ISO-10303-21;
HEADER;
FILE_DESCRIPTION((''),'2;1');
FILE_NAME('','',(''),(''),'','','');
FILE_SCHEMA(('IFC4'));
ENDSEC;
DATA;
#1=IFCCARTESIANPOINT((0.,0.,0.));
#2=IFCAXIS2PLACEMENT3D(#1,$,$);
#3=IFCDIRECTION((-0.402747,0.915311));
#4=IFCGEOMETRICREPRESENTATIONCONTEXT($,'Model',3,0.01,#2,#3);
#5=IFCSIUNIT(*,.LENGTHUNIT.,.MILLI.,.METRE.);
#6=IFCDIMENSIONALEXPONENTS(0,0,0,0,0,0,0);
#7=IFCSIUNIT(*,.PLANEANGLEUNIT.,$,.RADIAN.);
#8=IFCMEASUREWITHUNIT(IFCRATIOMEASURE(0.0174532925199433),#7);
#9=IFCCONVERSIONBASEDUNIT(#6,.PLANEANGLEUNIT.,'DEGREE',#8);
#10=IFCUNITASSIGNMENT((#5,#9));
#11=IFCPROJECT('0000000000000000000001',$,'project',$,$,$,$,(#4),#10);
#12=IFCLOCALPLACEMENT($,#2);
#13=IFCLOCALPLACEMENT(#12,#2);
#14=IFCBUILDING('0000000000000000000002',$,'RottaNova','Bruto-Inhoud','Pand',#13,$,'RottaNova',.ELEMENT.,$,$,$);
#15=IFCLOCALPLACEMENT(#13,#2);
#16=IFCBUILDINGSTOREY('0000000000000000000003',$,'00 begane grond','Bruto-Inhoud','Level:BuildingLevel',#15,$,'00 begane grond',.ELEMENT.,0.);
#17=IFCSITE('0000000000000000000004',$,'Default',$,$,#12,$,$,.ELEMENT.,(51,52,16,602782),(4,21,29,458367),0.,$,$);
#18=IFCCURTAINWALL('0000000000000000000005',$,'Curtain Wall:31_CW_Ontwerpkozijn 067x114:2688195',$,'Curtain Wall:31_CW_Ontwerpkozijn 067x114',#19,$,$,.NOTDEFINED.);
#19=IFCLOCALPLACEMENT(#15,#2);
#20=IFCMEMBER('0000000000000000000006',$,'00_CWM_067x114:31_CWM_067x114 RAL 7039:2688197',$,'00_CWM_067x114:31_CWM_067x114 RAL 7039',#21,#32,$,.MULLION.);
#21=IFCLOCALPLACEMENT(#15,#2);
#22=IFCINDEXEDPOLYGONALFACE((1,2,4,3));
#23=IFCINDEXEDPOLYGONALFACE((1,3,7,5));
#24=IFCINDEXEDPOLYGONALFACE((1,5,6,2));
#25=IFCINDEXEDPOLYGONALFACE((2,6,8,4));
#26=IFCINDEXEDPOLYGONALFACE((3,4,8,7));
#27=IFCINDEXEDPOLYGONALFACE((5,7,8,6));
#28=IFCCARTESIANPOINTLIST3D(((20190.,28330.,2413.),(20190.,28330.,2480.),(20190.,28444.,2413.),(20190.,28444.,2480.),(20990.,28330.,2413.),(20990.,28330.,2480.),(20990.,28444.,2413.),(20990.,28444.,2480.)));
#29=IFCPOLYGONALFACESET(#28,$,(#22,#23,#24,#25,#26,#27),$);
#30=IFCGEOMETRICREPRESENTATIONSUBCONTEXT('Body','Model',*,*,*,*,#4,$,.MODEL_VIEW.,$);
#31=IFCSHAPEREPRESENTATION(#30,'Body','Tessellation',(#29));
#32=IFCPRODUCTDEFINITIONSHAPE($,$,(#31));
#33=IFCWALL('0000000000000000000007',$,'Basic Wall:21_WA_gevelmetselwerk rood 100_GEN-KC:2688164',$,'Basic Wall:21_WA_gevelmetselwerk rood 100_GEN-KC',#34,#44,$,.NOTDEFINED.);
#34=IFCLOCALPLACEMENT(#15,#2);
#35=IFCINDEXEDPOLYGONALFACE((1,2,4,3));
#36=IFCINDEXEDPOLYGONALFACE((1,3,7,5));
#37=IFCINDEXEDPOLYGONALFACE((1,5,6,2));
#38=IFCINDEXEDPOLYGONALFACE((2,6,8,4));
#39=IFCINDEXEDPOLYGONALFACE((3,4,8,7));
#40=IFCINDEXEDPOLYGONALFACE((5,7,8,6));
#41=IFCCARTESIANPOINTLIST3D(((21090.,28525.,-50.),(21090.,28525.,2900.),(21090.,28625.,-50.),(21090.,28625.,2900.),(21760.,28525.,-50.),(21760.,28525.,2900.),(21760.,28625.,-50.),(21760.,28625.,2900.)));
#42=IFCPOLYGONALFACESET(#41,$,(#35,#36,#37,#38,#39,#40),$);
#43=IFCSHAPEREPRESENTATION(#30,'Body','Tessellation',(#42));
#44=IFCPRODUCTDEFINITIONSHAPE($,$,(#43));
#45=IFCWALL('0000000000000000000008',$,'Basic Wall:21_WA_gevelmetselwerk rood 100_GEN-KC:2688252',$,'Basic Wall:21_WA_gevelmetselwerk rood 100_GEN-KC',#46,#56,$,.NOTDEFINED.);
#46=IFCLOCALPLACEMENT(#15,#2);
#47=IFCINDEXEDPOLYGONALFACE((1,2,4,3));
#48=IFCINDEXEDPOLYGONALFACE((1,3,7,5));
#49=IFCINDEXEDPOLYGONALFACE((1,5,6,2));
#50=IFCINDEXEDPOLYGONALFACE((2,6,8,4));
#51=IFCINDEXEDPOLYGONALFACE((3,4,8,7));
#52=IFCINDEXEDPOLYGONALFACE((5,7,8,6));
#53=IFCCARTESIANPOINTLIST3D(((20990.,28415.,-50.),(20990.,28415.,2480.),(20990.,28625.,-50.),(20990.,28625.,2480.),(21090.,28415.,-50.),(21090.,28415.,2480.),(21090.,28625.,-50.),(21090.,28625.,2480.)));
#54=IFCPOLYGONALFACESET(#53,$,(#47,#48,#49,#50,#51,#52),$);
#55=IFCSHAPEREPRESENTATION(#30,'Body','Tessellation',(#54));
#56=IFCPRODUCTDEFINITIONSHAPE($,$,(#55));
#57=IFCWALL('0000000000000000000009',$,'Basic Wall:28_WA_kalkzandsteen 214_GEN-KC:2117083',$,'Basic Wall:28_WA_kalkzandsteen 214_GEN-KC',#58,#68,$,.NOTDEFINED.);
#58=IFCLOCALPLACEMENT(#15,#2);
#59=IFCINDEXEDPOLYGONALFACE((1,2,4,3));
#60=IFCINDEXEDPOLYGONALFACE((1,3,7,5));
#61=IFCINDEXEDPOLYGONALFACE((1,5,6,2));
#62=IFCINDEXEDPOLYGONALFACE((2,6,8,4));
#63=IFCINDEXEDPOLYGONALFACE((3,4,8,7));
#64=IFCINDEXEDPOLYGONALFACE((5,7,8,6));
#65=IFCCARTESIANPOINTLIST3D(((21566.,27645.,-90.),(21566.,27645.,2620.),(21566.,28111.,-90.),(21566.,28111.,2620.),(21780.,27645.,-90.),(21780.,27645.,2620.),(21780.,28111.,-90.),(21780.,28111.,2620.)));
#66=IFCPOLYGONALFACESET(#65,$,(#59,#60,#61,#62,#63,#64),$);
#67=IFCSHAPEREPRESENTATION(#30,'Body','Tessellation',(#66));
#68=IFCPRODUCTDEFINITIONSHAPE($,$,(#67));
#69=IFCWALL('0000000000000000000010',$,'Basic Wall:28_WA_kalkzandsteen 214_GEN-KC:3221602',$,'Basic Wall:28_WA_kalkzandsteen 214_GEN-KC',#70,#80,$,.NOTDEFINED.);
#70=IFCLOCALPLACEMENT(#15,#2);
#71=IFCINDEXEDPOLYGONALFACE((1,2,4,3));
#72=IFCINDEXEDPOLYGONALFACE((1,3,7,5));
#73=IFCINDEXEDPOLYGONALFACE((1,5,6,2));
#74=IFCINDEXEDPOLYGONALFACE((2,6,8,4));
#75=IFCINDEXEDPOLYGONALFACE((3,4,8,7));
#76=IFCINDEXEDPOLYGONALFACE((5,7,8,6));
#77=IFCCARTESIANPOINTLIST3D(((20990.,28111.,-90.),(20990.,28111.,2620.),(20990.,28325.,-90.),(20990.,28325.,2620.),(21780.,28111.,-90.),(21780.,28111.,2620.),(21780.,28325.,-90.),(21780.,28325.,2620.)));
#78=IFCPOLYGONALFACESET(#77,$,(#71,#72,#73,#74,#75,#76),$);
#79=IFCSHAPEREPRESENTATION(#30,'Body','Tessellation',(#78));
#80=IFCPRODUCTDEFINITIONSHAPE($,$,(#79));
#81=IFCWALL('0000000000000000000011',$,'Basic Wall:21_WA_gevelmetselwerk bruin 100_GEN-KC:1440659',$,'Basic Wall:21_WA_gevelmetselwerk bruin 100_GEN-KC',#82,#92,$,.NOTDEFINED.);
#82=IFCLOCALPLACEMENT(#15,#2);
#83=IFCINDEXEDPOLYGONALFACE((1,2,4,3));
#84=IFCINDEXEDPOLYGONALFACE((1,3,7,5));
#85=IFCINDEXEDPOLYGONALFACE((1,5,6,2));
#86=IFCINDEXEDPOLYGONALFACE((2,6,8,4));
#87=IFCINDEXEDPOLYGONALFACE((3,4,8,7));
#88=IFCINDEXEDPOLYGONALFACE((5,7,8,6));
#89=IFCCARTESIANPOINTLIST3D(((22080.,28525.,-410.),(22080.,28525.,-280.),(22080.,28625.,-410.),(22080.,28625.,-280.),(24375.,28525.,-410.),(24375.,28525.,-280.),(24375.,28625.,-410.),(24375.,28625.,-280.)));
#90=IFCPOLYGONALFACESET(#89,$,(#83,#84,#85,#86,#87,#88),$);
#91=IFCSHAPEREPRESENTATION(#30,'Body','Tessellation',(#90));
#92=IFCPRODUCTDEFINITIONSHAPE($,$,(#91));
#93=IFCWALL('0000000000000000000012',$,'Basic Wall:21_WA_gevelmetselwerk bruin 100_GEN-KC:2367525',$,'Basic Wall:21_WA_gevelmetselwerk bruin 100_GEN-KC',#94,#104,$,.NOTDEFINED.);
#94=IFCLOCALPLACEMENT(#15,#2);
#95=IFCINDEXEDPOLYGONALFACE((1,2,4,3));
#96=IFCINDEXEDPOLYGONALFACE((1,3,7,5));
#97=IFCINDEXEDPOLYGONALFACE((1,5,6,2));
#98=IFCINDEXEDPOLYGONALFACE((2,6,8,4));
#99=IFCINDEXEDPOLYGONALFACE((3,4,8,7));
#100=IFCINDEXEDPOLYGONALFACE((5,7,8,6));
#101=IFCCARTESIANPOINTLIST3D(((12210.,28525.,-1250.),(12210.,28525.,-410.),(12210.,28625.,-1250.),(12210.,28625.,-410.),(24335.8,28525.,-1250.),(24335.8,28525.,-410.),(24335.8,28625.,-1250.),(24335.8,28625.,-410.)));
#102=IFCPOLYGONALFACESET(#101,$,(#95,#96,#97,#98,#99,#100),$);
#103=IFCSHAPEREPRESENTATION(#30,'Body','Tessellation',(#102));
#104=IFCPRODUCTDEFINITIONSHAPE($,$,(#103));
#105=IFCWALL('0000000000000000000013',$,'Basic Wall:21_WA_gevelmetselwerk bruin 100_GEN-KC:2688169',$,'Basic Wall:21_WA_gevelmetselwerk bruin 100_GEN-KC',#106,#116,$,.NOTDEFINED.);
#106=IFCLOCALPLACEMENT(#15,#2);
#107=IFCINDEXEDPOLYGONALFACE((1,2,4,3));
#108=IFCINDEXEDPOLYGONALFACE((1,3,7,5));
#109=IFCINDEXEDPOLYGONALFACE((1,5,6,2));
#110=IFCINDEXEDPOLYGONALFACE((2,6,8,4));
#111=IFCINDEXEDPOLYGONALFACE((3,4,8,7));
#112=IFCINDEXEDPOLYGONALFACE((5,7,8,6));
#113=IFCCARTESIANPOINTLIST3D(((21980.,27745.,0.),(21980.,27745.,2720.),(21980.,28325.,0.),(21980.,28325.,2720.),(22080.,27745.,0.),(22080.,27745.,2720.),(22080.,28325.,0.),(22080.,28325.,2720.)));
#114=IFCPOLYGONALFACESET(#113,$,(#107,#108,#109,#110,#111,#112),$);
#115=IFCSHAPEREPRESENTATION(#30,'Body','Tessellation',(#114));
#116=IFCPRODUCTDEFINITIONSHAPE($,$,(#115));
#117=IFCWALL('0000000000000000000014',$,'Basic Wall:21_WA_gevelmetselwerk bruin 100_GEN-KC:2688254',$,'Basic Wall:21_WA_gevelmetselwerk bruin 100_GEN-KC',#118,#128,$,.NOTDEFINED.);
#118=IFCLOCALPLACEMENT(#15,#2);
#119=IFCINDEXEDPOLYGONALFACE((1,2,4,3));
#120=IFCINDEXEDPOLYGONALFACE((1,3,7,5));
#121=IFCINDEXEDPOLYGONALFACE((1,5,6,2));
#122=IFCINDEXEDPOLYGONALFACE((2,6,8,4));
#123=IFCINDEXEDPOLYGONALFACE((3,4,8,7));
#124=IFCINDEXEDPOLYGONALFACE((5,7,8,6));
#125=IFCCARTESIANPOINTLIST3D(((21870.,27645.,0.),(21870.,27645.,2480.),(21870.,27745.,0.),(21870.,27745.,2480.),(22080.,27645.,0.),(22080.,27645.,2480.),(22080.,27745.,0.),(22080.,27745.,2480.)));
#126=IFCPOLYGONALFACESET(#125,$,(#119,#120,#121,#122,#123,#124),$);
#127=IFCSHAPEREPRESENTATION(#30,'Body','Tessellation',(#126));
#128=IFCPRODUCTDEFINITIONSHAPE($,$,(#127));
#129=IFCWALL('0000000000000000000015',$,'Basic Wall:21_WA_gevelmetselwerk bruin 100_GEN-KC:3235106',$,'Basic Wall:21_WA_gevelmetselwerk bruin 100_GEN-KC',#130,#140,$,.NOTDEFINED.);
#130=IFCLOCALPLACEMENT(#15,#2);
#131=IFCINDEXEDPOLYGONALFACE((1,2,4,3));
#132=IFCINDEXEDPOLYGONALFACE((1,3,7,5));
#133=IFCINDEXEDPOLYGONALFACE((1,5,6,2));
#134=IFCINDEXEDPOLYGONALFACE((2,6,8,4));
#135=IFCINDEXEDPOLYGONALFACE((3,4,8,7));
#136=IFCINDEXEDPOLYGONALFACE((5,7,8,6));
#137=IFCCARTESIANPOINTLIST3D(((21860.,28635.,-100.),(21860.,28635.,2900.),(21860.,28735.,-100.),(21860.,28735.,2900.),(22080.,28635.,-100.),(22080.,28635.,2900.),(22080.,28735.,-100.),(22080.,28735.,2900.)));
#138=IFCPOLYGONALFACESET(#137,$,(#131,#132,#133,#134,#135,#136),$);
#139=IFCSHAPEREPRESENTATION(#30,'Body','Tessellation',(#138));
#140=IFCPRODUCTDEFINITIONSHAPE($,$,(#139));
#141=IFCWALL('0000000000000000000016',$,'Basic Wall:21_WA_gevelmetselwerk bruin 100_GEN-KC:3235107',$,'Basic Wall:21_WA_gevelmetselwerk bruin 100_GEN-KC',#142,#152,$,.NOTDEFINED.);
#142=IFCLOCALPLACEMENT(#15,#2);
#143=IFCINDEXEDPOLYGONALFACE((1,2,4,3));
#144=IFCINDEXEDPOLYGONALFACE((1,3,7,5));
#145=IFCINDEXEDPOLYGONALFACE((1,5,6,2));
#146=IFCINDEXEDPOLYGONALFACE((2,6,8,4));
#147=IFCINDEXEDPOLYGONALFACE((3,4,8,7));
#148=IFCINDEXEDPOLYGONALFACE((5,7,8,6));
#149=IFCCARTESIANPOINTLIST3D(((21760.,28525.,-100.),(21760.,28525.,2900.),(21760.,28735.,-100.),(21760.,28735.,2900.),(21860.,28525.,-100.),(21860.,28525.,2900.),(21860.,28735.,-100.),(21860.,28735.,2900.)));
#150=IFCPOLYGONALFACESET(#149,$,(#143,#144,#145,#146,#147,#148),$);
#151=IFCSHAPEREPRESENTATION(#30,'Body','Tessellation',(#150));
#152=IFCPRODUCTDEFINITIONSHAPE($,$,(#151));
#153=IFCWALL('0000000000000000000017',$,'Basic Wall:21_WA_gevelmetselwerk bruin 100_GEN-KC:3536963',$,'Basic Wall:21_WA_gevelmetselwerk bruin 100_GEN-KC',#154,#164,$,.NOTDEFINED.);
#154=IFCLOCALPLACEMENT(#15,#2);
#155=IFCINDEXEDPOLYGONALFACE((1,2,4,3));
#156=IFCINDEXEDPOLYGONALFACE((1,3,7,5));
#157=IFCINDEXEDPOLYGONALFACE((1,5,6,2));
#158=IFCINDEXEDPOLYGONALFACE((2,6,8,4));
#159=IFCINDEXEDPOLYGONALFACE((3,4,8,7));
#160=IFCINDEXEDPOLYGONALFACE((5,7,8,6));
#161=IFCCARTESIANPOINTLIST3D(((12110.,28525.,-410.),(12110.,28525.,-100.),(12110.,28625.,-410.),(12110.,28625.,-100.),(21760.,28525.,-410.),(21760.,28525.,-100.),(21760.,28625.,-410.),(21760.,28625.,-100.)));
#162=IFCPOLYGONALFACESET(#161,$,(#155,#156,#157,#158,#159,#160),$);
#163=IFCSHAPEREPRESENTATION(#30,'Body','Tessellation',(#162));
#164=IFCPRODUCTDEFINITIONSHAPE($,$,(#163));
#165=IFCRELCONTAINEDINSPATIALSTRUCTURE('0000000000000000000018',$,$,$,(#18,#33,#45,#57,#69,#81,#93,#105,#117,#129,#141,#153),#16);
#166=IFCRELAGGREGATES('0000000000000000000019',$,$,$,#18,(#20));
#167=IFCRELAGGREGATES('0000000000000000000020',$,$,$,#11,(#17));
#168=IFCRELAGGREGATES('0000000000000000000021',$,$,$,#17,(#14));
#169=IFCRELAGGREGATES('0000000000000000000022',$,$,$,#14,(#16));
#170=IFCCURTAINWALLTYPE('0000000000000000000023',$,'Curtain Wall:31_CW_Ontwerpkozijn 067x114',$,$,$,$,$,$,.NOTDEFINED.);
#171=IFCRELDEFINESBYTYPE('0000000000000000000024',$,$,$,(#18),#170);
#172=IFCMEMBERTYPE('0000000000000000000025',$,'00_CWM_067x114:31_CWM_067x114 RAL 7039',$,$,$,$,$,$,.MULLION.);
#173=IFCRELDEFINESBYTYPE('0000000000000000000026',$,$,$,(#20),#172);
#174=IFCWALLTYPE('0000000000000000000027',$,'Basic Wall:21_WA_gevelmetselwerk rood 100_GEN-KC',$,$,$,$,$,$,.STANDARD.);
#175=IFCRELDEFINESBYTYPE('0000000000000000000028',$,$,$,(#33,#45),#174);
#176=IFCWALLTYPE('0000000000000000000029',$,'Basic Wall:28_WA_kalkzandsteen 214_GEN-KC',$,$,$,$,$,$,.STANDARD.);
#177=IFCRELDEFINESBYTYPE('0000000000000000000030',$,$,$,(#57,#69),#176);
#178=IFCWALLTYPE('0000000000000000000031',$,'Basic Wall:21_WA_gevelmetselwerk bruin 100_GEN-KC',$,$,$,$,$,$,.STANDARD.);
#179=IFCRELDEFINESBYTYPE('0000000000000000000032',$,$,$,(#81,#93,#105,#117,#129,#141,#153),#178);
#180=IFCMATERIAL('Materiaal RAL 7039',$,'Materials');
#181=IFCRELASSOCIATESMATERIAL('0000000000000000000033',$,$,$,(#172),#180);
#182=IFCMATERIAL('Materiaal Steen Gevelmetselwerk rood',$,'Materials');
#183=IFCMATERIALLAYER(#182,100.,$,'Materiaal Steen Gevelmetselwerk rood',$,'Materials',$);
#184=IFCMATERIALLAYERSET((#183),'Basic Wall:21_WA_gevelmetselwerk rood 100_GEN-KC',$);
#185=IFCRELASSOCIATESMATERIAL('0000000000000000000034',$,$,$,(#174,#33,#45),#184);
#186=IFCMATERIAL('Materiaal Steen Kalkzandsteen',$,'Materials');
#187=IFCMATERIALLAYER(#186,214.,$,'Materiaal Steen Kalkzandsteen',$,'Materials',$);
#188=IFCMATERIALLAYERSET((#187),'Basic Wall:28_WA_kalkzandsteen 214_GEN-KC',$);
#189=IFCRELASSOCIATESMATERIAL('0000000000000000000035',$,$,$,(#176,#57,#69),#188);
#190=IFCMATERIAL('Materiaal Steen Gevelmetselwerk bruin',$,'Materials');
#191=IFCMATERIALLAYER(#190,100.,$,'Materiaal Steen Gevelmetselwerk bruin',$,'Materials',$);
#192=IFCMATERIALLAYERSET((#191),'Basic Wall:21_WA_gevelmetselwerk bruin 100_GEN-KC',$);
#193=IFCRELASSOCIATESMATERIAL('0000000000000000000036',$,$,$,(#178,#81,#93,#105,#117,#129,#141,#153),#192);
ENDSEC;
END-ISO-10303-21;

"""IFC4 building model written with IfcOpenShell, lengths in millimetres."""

from ifc_helpers import new_model, entity, si_unit, converted_unit, direction, frame, frame_2d, origin, origin_2d_with_axis, place, context, subcontext, project, spatial, rectangle, extrude, source, transform, mapped, material, layer, layer_set, material_profile, profile_set, type_object, type_shapes, element, aggregate, save


model = new_model("IFC4")

# Units and contexts
model_context = context("Model", 3, precision=0.01, world=origin(), true_north=direction((-0.402747, 0.915311)))
body_context = subcontext(model_context, "Body", "Model", "MODEL_VIEW")
ifc_project = project(units=[si_unit("LENGTHUNIT", "METRE", prefix="MILLI"), converted_unit("PLANEANGLEUNIT", "DEGREE", entity("IfcRatioMeasure", 0.0174532925199433), si_unit("PLANEANGLEUNIT", "RADIAN"), dimensions=[0, 0, 0, 0, 0, 0, 0])], contexts=[model_context])

# Site, building, storey
site_placement = place(None, origin())
site = spatial("IfcSite", under=ifc_project, at=site_placement, Name="Default", CompositionType="ELEMENT", RefLatitude=(51, 52, 16, 602782), RefLongitude=(4, 21, 29, 458367), RefElevation=0.0)
building_placement = place(site_placement, origin())
building = spatial("IfcBuilding", under=site, at=building_placement, Name="RottaNova", Description="Bruto-Inhoud", ObjectType="Pand", LongName="RottaNova", CompositionType="ELEMENT")
storey_placement = place(building_placement, origin())
storey = spatial("IfcBuildingStorey", under=building, at=storey_placement, Name="00 begane grond", Description="Bruto-Inhoud", ObjectType="Level:BuildingLevel", LongName="00 begane grond", CompositionType="ELEMENT", Elevation=0.0)

# Curtain wall, member
curtain_wall_type = type_object("IfcCurtainWallType", Name="Curtain Wall:31_CW_Ontwerpkozijn 067x114", PredefinedType="NOTDEFINED")
ifc_material_1 = material(Name="Materiaal RAL 7039", Category="Materials")
curtain_wall_1_placement = place(storey_placement, origin())
curtain_wall_1 = element("IfcCurtainWall", 1, at=curtain_wall_1_placement, inside=storey, type_object=curtain_wall_type, Name="Curtain Wall:31_CW_Ontwerpkozijn 067x114:2688195", ObjectType="Curtain Wall:31_CW_Ontwerpkozijn 067x114", PredefinedType="NOTDEFINED")
ifc_material_profile_1 = material_profile(ifc_material_1, rectangle(XDim=114.0, YDim=67.0, at=origin_2d_with_axis()), Name="31_CWM_067x114 RAL 7039")
ifc_profile_set_1 = profile_set([ifc_material_profile_1], Name="31_CWM_067x114 RAL 7039")
member_type_1 = type_object("IfcMemberType", Name="00_CWM_067x114:31_CWM_067x114 RAL 7039", PredefinedType="MULLION", material=ifc_profile_set_1)
shared_shape_1 = source(origin(), body_context, "Body", "SweptSolid", [
    extrude(rectangle(XDim=114.0, YDim=67.0, at=frame_2d((0.0, 0.0), x_axis=(1.0, 0.0))), frame((-33.5, -57.0, -800.0), z_axis=(0.0, 0.0, 1.0), x_axis=(0.0, -1.0, 0.0)), (0.0, 0.0, 1.0), 800.0),
])
type_shapes(member_type_1, [shared_shape_1])
member_1_placement = place(curtain_wall_1_placement, frame((20990.0, 28330.0, 2480.0), z_axis=(1.0, 0.0, 0.0), x_axis=(0.0, 0.0, 1.0)))
member_1 = element("IfcMember", 2, at=member_1_placement, type_object=member_type_1, Name="00_CWM_067x114:31_CWM_067x114 RAL 7039:2688197", ObjectType="00_CWM_067x114:31_CWM_067x114 RAL 7039", PredefinedType="MULLION", context=body_context, shape_type="MappedRepresentation", body=[
    mapped(shared_shape_1, transform((0.0, 0.0, 0.0), scale=1.0)),
])
aggregate(curtain_wall_1, [member_1])

# Walls
ifc_material_2 = material(Name="Materiaal Steen Gevelmetselwerk rood", Category="Materials")
ifc_layer_1 = layer(ifc_material_2, 100.0, Name="Materiaal Steen Gevelmetselwerk rood", Category="Materials")
ifc_layer_set_1 = layer_set([ifc_layer_1], Name="Basic Wall:21_WA_gevelmetselwerk rood 100_GEN-KC")
wall_type_1 = type_object("IfcWallType", Name="Basic Wall:21_WA_gevelmetselwerk rood 100_GEN-KC", PredefinedType="STANDARD", material=ifc_layer_set_1)
wall_1_placement = place(storey_placement, frame((21760.0, 28575.0, -50.0), z_axis=(0.0, 0.0, 1.0), x_axis=(-1.0, 0.0, 0.0)))
element("IfcWall", 3, at=wall_1_placement, inside=storey, type_object=wall_type_1, material=ifc_layer_set_1, Name="Basic Wall:21_WA_gevelmetselwerk rood 100_GEN-KC:2688164", ObjectType="Basic Wall:21_WA_gevelmetselwerk rood 100_GEN-KC", PredefinedType="NOTDEFINED", context=body_context, shape_type="SweptSolid", body=[
    extrude(rectangle(XDim=670.0, YDim=100.0, at=frame_2d((335.0, 0.0), x_axis=(-1.0, 0.0))), origin(), (0.0, 0.0, 1.0), 2950.0),
])
wall_2_placement = place(storey_placement, frame((21040.0, 28415.0, -50.0), z_axis=(0.0, 0.0, 1.0), x_axis=(0.0, 1.0, 0.0)))
element("IfcWall", 4, at=wall_2_placement, inside=storey, type_object=wall_type_1, material=ifc_layer_set_1, Name="Basic Wall:21_WA_gevelmetselwerk rood 100_GEN-KC:2688252", ObjectType="Basic Wall:21_WA_gevelmetselwerk rood 100_GEN-KC", PredefinedType="NOTDEFINED", context=body_context, shape_type="SweptSolid", body=[
    extrude(rectangle(XDim=210.0, YDim=100.0, at=frame_2d((105.0, 0.0), x_axis=(-1.0, 0.0))), origin(), (0.0, 0.0, 1.0), 2530.0),
])
ifc_material_3 = material(Name="Materiaal Steen Kalkzandsteen", Category="Materials")
ifc_layer_2 = layer(ifc_material_3, 214.0, Name="Materiaal Steen Kalkzandsteen", Category="Materials")
ifc_layer_set_2 = layer_set([ifc_layer_2], Name="Basic Wall:28_WA_kalkzandsteen 214_GEN-KC")
wall_type_2 = type_object("IfcWallType", Name="Basic Wall:28_WA_kalkzandsteen 214_GEN-KC", PredefinedType="STANDARD", material=ifc_layer_set_2)
wall_3_placement = place(storey_placement, frame((21673.0, 28111.0, -90.0), z_axis=(0.0, 0.0, 1.0), x_axis=(0.0, -1.0, 0.0)))
element("IfcWall", 5, at=wall_3_placement, inside=storey, type_object=wall_type_2, material=ifc_layer_set_2, Name="Basic Wall:28_WA_kalkzandsteen 214_GEN-KC:2117083", ObjectType="Basic Wall:28_WA_kalkzandsteen 214_GEN-KC", PredefinedType="NOTDEFINED", context=body_context, shape_type="SweptSolid", body=[
    extrude(rectangle(XDim=466.0, YDim=214.0, at=frame_2d((233.0, 0.0), x_axis=(-1.0, 0.0))), origin(), (0.0, 0.0, 1.0), 2710.0),
])
wall_4_placement = place(storey_placement, frame((20990.0, 28218.0, -90.0)))
element("IfcWall", 6, at=wall_4_placement, inside=storey, type_object=wall_type_2, material=ifc_layer_set_2, Name="Basic Wall:28_WA_kalkzandsteen 214_GEN-KC:3221602", ObjectType="Basic Wall:28_WA_kalkzandsteen 214_GEN-KC", PredefinedType="NOTDEFINED", context=body_context, shape_type="SweptSolid", body=[
    extrude(rectangle(XDim=790.0, YDim=214.0, at=frame_2d((395.0, 0.0), x_axis=(-1.0, 0.0))), origin(), (0.0, 0.0, 1.0), 2710.0),
])
ifc_material_4 = material(Name="Materiaal Steen Gevelmetselwerk bruin", Category="Materials")
ifc_layer_3 = layer(ifc_material_4, 100.0, Name="Materiaal Steen Gevelmetselwerk bruin", Category="Materials")
ifc_layer_set_3 = layer_set([ifc_layer_3], Name="Basic Wall:21_WA_gevelmetselwerk bruin 100_GEN-KC")
wall_type_3 = type_object("IfcWallType", Name="Basic Wall:21_WA_gevelmetselwerk bruin 100_GEN-KC", PredefinedType="STANDARD", material=ifc_layer_set_3)
wall_5_placement = place(storey_placement, frame((22080.0, 28575.0, -410.0)))
element("IfcWall", 7, at=wall_5_placement, inside=storey, type_object=wall_type_3, material=ifc_layer_set_3, Name="Basic Wall:21_WA_gevelmetselwerk bruin 100_GEN-KC:1440659", ObjectType="Basic Wall:21_WA_gevelmetselwerk bruin 100_GEN-KC", PredefinedType="NOTDEFINED", context=body_context, shape_type="SweptSolid", body=[
    extrude(rectangle(XDim=2295.0, YDim=100.0, at=frame_2d((1147.5, 0.0), x_axis=(-1.0, 0.0))), origin(), (0.0, 0.0, 1.0), 130.0),
])
wall_6_placement = place(storey_placement, frame((24335.8, 28575.0, -1250.0), z_axis=(0.0, 0.0, 1.0), x_axis=(-1.0, 0.0, 0.0)))
element("IfcWall", 8, at=wall_6_placement, inside=storey, type_object=wall_type_3, material=ifc_layer_set_3, Name="Basic Wall:21_WA_gevelmetselwerk bruin 100_GEN-KC:2367525", ObjectType="Basic Wall:21_WA_gevelmetselwerk bruin 100_GEN-KC", PredefinedType="NOTDEFINED", context=body_context, shape_type="SweptSolid", body=[
    extrude(rectangle(XDim=12125.8, YDim=100.0, at=frame_2d((6062.9, 0.0), x_axis=(-1.0, 0.0))), origin(), (0.0, 0.0, 1.0), 840.0),
])
wall_7_placement = place(storey_placement, frame((22030.0, 27745.0, 0.0), z_axis=(0.0, 0.0, 1.0), x_axis=(0.0, 1.0, 0.0)))
element("IfcWall", 9, at=wall_7_placement, inside=storey, type_object=wall_type_3, material=ifc_layer_set_3, Name="Basic Wall:21_WA_gevelmetselwerk bruin 100_GEN-KC:2688169", ObjectType="Basic Wall:21_WA_gevelmetselwerk bruin 100_GEN-KC", PredefinedType="NOTDEFINED", context=body_context, shape_type="SweptSolid", body=[
    extrude(rectangle(XDim=580.0, YDim=100.0, at=frame_2d((290.0, 0.0), x_axis=(-1.0, 0.0))), origin(), (0.0, 0.0, 1.0), 2720.0),
])
wall_8_placement = place(storey_placement, frame((21870.0, 27695.0, 0.0)))
element("IfcWall", 10, at=wall_8_placement, inside=storey, type_object=wall_type_3, material=ifc_layer_set_3, Name="Basic Wall:21_WA_gevelmetselwerk bruin 100_GEN-KC:2688254", ObjectType="Basic Wall:21_WA_gevelmetselwerk bruin 100_GEN-KC", PredefinedType="NOTDEFINED", context=body_context, shape_type="SweptSolid", body=[
    extrude(rectangle(XDim=210.0, YDim=100.0, at=frame_2d((105.0, 0.0), x_axis=(-1.0, 0.0))), origin(), (0.0, 0.0, 1.0), 2480.0),
])
wall_9_placement = place(storey_placement, frame((22080.0, 28685.0, -100.0), z_axis=(0.0, 0.0, 1.0), x_axis=(-1.0, 0.0, 0.0)))
element("IfcWall", 11, at=wall_9_placement, inside=storey, type_object=wall_type_3, material=ifc_layer_set_3, Name="Basic Wall:21_WA_gevelmetselwerk bruin 100_GEN-KC:3235106", ObjectType="Basic Wall:21_WA_gevelmetselwerk bruin 100_GEN-KC", PredefinedType="NOTDEFINED", context=body_context, shape_type="SweptSolid", body=[
    extrude(rectangle(XDim=220.0, YDim=100.0, at=frame_2d((110.0, 0.0), x_axis=(-1.0, 0.0))), origin(), (0.0, 0.0, 1.0), 3000.0),
])
wall_10_placement = place(storey_placement, frame((21810.0, 28735.0, -100.0), z_axis=(0.0, 0.0, 1.0), x_axis=(0.0, -1.0, 0.0)))
element("IfcWall", 12, at=wall_10_placement, inside=storey, type_object=wall_type_3, material=ifc_layer_set_3, Name="Basic Wall:21_WA_gevelmetselwerk bruin 100_GEN-KC:3235107", ObjectType="Basic Wall:21_WA_gevelmetselwerk bruin 100_GEN-KC", PredefinedType="NOTDEFINED", context=body_context, shape_type="SweptSolid", body=[
    extrude(rectangle(XDim=210.0, YDim=100.0, at=frame_2d((105.0, 0.0), x_axis=(-1.0, 0.0))), origin(), (0.0, 0.0, 1.0), 3000.0),
])
wall_11_placement = place(storey_placement, frame((21760.0, 28575.0, -410.0), z_axis=(0.0, 0.0, 1.0), x_axis=(-1.0, 0.0, 0.0)))
element("IfcWall", 13, at=wall_11_placement, inside=storey, type_object=wall_type_3, material=ifc_layer_set_3, Name="Basic Wall:21_WA_gevelmetselwerk bruin 100_GEN-KC:3536963", ObjectType="Basic Wall:21_WA_gevelmetselwerk bruin 100_GEN-KC", PredefinedType="NOTDEFINED", context=body_context, shape_type="SweptSolid", body=[
    extrude(rectangle(XDim=9650.0, YDim=100.0, at=frame_2d((4825.0, 0.0), x_axis=(-1.0, 0.0))), origin(), (0.0, 0.0, 1.0), 310.0),
])

save(model, "model.ifc")
